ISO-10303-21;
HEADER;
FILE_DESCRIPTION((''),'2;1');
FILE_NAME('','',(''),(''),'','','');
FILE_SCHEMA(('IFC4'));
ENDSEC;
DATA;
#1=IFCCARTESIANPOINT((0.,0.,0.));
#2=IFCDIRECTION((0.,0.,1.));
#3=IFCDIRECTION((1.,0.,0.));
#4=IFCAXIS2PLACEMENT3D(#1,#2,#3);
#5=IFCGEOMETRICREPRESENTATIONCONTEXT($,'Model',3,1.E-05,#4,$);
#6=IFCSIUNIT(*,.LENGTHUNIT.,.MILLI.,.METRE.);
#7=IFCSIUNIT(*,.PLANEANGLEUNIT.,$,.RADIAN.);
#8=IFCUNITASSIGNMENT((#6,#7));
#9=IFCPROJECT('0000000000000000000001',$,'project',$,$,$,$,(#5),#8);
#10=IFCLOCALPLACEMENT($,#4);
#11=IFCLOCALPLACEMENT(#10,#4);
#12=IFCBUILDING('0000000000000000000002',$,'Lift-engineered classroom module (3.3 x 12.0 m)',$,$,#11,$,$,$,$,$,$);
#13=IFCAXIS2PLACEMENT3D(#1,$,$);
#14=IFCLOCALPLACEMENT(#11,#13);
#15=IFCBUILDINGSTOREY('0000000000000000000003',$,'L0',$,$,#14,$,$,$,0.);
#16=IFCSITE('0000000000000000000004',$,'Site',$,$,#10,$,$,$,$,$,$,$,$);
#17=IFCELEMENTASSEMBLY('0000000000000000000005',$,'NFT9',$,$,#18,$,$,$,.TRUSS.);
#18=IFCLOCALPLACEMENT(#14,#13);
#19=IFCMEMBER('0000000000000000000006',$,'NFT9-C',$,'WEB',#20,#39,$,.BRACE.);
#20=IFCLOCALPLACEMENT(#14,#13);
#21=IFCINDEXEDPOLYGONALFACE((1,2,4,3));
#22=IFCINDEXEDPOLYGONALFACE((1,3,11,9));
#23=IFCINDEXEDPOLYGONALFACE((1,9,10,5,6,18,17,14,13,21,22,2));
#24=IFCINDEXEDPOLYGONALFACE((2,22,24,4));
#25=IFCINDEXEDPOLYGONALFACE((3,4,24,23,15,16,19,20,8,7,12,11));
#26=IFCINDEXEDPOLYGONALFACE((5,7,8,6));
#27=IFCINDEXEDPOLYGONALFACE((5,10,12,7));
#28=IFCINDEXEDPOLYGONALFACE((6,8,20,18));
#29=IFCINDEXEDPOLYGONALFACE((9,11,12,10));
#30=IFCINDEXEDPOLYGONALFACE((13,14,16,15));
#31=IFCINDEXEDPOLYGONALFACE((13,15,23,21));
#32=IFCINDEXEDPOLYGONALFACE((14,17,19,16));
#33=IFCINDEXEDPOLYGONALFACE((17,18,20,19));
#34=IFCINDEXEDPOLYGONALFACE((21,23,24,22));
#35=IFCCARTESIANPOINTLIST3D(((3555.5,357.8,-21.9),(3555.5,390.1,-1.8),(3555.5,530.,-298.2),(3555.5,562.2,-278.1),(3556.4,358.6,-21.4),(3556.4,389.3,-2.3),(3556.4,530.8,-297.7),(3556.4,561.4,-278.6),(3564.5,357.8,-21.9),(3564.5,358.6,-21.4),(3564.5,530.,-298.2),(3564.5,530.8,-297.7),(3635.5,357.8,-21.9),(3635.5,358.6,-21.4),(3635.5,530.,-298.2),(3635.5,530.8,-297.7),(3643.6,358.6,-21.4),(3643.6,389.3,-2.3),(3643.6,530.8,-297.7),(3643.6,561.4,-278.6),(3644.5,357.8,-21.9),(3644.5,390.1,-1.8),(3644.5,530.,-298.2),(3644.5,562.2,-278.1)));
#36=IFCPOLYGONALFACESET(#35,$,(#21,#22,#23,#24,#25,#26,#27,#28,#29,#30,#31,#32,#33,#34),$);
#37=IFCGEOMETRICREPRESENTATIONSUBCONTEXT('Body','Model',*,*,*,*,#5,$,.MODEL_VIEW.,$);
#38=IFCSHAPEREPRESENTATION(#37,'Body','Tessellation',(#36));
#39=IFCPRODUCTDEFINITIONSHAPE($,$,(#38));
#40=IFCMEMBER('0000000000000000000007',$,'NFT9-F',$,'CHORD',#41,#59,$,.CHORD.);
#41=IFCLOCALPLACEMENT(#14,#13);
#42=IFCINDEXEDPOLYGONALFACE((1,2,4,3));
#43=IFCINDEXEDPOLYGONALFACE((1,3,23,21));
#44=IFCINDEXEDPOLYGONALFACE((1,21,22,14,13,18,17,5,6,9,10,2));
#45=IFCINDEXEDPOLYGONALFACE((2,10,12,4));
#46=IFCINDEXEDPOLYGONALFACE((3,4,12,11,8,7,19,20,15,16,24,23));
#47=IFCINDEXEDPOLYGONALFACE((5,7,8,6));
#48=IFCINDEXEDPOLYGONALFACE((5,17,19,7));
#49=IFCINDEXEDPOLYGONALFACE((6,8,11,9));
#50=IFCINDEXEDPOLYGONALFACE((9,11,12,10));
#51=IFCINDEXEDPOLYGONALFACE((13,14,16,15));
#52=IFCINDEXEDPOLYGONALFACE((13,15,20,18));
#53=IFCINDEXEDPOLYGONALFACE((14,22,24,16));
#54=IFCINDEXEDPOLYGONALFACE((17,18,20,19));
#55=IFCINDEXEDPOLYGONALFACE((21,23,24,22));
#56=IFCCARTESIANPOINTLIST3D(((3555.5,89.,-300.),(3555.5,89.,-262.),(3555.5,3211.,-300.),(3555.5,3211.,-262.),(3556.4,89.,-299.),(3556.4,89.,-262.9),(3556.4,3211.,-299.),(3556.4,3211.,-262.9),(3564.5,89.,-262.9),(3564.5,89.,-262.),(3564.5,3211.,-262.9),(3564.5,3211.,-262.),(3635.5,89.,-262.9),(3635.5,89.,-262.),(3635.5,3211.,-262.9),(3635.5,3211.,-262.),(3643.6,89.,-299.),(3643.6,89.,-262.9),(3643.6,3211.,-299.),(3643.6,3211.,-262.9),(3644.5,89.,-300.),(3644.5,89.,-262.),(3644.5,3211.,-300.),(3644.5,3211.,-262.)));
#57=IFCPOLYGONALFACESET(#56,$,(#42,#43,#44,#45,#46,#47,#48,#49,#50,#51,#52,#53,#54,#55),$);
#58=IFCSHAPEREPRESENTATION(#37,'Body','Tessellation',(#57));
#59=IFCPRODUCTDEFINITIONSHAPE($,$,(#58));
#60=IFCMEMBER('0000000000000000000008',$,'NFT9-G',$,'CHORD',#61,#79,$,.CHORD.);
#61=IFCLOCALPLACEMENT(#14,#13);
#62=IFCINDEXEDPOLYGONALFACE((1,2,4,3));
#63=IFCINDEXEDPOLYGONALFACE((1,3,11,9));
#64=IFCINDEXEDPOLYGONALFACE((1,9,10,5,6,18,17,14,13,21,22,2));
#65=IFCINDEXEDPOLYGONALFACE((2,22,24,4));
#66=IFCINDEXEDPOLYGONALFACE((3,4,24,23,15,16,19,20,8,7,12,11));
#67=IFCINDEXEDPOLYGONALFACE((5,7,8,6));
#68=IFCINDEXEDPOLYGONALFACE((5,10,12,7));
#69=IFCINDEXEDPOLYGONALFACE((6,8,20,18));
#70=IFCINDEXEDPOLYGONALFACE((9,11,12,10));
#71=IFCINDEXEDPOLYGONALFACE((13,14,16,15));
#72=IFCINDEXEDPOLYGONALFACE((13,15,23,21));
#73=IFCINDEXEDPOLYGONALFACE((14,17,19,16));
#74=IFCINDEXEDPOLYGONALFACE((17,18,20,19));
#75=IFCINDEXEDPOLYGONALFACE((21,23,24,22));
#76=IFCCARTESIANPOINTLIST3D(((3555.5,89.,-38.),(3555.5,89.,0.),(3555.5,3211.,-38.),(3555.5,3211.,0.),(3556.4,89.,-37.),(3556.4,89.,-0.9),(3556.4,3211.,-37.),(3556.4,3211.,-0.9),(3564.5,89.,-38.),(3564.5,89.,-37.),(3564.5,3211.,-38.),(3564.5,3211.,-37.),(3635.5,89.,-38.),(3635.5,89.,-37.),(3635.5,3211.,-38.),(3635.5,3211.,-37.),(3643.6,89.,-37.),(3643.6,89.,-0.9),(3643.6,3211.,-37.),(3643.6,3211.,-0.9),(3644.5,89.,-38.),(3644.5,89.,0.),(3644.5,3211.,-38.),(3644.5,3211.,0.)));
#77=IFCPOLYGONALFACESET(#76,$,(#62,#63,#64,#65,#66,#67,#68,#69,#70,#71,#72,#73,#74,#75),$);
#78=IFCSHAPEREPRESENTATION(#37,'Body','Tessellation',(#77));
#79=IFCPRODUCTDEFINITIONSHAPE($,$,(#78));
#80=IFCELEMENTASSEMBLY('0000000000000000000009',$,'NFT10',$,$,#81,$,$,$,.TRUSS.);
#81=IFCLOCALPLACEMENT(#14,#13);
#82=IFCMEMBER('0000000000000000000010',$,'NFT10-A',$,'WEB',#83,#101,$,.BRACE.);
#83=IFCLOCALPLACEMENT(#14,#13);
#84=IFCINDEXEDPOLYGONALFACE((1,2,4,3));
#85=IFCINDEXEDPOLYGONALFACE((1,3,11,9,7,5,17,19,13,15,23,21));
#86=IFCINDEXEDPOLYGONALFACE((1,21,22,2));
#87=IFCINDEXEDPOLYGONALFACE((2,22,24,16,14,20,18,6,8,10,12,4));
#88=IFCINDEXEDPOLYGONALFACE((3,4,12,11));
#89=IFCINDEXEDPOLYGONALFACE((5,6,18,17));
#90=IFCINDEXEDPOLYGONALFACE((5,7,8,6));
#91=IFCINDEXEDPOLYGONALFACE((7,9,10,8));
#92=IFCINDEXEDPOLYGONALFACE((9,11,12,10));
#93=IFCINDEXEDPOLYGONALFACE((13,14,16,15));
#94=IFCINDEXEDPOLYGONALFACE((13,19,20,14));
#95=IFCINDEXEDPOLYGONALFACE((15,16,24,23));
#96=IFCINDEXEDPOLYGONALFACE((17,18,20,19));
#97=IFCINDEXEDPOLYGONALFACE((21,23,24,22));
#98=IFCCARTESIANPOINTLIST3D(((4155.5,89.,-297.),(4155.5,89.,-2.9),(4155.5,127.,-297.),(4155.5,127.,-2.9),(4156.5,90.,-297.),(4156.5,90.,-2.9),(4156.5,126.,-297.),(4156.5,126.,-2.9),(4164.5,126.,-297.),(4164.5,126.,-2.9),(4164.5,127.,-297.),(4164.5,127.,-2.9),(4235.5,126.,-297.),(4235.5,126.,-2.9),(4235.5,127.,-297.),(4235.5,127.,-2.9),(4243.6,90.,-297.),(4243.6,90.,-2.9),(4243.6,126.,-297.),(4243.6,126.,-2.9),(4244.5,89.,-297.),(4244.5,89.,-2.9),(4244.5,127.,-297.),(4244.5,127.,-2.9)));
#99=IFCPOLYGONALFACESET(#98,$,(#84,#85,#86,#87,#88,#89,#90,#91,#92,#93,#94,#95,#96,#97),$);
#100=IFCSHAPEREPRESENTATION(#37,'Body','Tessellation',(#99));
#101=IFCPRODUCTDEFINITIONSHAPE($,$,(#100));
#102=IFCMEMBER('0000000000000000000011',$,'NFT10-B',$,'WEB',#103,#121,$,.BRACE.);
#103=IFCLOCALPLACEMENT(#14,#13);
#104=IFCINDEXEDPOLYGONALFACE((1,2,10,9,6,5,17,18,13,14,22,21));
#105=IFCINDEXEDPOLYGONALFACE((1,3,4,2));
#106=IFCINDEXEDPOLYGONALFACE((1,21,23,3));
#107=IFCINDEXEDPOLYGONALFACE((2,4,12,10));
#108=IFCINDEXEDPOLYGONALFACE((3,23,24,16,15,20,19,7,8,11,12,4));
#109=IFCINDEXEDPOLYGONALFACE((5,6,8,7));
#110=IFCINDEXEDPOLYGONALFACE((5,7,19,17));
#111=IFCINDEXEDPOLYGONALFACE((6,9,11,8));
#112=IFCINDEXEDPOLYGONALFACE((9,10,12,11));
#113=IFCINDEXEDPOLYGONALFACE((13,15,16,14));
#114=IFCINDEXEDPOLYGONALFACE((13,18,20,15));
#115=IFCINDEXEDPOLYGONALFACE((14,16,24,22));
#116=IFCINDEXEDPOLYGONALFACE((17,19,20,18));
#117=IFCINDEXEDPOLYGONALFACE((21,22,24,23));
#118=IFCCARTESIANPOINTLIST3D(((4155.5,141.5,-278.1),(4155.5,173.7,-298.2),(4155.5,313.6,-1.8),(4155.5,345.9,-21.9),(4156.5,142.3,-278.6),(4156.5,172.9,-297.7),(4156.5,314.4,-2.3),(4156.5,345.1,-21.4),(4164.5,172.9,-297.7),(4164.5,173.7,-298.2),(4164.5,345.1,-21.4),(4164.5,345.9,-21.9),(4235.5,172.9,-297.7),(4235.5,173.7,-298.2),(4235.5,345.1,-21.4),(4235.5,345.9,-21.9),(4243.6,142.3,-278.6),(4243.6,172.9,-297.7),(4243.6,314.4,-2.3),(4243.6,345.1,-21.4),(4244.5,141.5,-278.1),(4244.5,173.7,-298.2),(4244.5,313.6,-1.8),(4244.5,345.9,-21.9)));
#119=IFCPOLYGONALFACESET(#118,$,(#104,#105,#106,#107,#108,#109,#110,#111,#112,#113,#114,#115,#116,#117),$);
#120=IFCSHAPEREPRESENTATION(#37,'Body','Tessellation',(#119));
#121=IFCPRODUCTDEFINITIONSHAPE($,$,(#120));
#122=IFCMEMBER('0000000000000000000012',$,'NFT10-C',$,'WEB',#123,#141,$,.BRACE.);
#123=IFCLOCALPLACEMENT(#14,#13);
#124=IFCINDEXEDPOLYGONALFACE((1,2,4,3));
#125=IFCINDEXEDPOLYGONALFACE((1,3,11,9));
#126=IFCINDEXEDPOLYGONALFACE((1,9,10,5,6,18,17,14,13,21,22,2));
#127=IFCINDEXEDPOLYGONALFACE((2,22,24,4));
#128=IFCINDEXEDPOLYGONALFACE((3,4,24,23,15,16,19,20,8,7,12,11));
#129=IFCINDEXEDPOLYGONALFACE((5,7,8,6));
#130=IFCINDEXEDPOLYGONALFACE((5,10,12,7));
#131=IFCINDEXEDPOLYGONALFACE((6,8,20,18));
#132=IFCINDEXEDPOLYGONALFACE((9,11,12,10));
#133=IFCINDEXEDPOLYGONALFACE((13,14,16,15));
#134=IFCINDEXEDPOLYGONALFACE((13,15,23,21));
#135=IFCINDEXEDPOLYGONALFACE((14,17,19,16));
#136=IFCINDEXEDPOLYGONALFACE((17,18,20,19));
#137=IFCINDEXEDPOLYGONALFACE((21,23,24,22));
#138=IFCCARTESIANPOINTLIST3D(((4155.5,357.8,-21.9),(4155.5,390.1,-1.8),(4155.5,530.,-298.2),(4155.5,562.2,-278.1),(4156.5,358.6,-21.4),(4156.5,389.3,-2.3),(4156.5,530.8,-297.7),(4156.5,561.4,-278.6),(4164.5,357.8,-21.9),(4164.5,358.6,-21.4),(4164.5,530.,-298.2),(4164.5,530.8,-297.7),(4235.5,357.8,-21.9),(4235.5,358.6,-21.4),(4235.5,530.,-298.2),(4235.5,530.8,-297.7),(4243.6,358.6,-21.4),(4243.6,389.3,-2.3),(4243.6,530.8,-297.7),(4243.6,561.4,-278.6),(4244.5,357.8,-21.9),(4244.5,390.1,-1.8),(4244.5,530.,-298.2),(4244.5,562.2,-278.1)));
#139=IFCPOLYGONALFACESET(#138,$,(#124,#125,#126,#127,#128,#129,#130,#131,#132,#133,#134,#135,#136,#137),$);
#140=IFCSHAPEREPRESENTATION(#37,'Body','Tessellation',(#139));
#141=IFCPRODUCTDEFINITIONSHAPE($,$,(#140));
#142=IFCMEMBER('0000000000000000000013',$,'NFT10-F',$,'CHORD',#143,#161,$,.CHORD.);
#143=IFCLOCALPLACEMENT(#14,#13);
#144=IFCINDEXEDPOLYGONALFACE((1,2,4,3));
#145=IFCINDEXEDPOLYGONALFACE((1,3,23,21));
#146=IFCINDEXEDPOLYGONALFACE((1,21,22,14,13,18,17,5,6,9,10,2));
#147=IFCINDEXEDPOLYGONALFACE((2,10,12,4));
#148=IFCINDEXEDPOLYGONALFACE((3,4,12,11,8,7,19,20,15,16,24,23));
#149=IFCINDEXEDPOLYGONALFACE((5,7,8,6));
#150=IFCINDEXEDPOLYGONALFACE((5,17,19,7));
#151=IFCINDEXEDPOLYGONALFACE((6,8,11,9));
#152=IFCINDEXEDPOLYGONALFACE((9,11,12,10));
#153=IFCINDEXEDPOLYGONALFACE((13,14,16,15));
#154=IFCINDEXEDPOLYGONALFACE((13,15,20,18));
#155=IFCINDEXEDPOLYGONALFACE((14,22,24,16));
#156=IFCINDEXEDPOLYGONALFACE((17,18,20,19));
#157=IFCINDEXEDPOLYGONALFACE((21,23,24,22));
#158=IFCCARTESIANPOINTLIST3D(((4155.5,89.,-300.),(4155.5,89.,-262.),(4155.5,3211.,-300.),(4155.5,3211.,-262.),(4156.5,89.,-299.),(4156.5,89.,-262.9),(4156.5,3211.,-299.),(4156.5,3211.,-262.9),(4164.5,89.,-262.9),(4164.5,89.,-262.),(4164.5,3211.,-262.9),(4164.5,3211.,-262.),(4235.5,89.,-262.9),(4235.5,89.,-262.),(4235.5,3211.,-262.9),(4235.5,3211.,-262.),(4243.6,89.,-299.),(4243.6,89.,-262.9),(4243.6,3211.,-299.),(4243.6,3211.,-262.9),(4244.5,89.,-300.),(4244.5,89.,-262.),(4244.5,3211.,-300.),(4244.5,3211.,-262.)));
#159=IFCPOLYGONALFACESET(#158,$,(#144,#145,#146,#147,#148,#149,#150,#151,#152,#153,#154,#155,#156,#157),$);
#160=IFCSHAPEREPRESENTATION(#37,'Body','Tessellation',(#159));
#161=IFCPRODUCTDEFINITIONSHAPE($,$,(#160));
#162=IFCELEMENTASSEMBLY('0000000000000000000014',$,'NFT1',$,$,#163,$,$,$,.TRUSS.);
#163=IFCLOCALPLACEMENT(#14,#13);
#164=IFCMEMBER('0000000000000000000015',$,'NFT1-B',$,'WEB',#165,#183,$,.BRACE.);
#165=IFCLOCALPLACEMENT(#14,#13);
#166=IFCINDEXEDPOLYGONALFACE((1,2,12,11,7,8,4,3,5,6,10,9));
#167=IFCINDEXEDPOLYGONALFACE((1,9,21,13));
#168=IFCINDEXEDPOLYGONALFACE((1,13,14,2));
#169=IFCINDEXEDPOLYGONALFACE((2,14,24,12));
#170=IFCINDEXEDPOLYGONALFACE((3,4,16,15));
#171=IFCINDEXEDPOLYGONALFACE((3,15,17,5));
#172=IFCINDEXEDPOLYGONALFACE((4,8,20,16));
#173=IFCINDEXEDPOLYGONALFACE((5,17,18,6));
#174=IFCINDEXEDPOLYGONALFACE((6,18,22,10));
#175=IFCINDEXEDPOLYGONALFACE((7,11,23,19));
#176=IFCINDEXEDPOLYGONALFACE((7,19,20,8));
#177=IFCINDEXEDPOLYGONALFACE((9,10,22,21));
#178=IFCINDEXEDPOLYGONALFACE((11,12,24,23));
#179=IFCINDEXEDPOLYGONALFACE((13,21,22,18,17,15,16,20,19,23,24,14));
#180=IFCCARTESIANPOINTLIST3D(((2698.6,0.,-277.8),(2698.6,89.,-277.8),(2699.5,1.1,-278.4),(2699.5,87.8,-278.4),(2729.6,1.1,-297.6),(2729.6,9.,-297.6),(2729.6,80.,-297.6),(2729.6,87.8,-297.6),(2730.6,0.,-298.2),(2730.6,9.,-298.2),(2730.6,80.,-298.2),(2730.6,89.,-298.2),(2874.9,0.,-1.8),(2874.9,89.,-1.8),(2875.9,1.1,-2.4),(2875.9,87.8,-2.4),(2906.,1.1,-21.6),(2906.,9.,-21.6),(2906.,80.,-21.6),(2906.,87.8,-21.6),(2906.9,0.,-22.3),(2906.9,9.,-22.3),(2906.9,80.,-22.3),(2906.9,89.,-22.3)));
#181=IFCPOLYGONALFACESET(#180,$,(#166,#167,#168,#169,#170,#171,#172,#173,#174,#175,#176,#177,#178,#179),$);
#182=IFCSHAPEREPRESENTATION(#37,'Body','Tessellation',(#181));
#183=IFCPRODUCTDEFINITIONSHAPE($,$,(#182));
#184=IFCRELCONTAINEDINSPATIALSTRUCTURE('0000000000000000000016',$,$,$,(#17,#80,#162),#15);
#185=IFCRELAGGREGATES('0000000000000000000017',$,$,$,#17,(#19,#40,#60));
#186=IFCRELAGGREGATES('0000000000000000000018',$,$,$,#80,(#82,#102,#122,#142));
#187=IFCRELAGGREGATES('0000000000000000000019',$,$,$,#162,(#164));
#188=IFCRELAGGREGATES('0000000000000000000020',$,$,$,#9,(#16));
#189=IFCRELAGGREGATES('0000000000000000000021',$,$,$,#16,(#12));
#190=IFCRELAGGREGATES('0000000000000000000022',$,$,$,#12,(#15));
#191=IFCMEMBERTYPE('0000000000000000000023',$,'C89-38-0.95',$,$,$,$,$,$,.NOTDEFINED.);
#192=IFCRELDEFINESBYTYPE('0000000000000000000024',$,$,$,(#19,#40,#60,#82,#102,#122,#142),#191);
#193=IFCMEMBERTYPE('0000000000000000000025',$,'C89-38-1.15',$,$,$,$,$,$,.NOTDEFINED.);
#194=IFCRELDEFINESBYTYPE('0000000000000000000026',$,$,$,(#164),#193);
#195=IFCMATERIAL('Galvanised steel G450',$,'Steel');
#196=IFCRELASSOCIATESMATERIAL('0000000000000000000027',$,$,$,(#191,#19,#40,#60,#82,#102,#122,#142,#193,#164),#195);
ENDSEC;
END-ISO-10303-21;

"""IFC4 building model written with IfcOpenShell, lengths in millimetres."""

from ifc_helpers import new_model, si_unit, frame, origin, origin_with_axes, origin_2d, place, context, subcontext, project, spatial, c_section, extrude, material, material_profile, profile_set, profile_usage, type_object, element, aggregate, save


model = new_model("IFC4")

# Units and contexts
model_context = context("Model", 3, precision=1e-05, world=origin_with_axes())
body_context = subcontext(model_context, "Body", "Model", "MODEL_VIEW")
ifc_project = project(units=[si_unit("LENGTHUNIT", "METRE", prefix="MILLI"), si_unit("PLANEANGLEUNIT", "RADIAN")], contexts=[model_context])

# Site, building, storey
site_placement = place(None, origin_with_axes())
site = spatial("IfcSite", under=ifc_project, at=site_placement, Name="Site")
building_placement = place(site_placement, origin_with_axes())
building = spatial("IfcBuilding", under=site, at=building_placement, Name="Lift-engineered classroom module (3.3 x 12.0 m)")
storey_placement = place(building_placement, origin())
storey = spatial("IfcBuildingStorey", under=building, at=storey_placement, Name="L0", Elevation=0.0)

# Element assemblies, members
ifc_material = material(Name="Galvanised steel G450", Category="Steel")
ifc_material_profile_1 = material_profile(ifc_material, c_section(Depth=89.0, Width=38.0, WallThickness=0.9, Girth=9.0, at=origin_2d()), Name="C89-38-0.95")
ifc_profile_set_1 = profile_set([ifc_material_profile_1], Name="C89-38-0.95")
ifc_profile_usage_1 = profile_usage(ifc_profile_set_1)
member_type_1 = type_object("IfcMemberType", Name="C89-38-0.95", PredefinedType="NOTDEFINED", material=ifc_profile_set_1)
assembly_1_placement = place(storey_placement, frame((3600.0, 89.0, -300.0)))
assembly_1 = element("IfcElementAssembly", 1, at=assembly_1_placement, inside=storey, Name="NFT9", PredefinedType="TRUSS")
member_1_placement = place(assembly_1_placement, frame((0.0, 457.1, 11.8), z_axis=(0.0, -0.528797, 0.848748), x_axis=(0.0, -0.848748, -0.528797)))
member_1 = element("IfcMember", 2, at=member_1_placement, type_object=member_type_1, material=ifc_profile_usage_1, Name="NFT9-C", ObjectType="WEB", PredefinedType="BRACE", context=body_context, shape_type="SweptSolid", body=[
    extrude(c_section(Depth=89.0, Width=38.0, WallThickness=0.9, Girth=9.0, at=origin_2d()), origin(), (0.0, 0.0, 1.0), 325.6),
])
member_2_placement = place(assembly_1_placement, frame((0.0, 0.0, 19.0), z_axis=(0.0, 1.0, 0.0), x_axis=(0.0, 0.0, 1.0)))
member_2 = element("IfcMember", 3, at=member_2_placement, type_object=member_type_1, material=ifc_profile_usage_1, Name="NFT9-F", ObjectType="CHORD", PredefinedType="CHORD", context=body_context, shape_type="SweptSolid", body=[
    extrude(c_section(Depth=89.0, Width=38.0, WallThickness=0.9, Girth=9.0, at=origin_2d()), origin(), (0.0, 0.0, 1.0), 3122.0),
])
member_3_placement = place(assembly_1_placement, frame((0.0, 0.0, 281.0), z_axis=(0.0, 1.0, 0.0), x_axis=(0.0, 0.0, -1.0)))
member_3 = element("IfcMember", 4, at=member_3_placement, type_object=member_type_1, material=ifc_profile_usage_1, Name="NFT9-G", ObjectType="CHORD", PredefinedType="CHORD", context=body_context, shape_type="SweptSolid", body=[
    extrude(c_section(Depth=89.0, Width=38.0, WallThickness=0.9, Girth=9.0, at=origin_2d()), origin(), (0.0, 0.0, 1.0), 3122.0),
])
aggregate(assembly_1, [member_1, member_2, member_3])
assembly_2_placement = place(storey_placement, frame((4200.0, 89.0, -300.0)))
assembly_2 = element("IfcElementAssembly", 5, at=assembly_2_placement, inside=storey, Name="NFT10", PredefinedType="TRUSS")
member_4_placement = place(assembly_2_placement, frame((0.0, 19.0, 2.9), z_axis=(0.0, 0.0, 1.0), x_axis=(0.0, 1.0, 0.0)))
member_4 = element("IfcMember", 6, at=member_4_placement, type_object=member_type_1, material=ifc_profile_usage_1, Name="NFT10-A", ObjectType="WEB", PredefinedType="BRACE", context=body_context, shape_type="SweptSolid", body=[
    extrude(c_section(Depth=89.0, Width=38.0, WallThickness=0.9, Girth=9.0, at=origin_2d()), origin(), (0.0, 0.0, 1.0), 294.1),
])
member_5_placement = place(assembly_2_placement, frame((0.0, 68.6, 11.8), z_axis=(0.0, 0.528797, 0.848748), x_axis=(0.0, 0.848748, -0.528797)))
member_5 = element("IfcMember", 7, at=member_5_placement, type_object=member_type_1, material=ifc_profile_usage_1, Name="NFT10-B", ObjectType="WEB", PredefinedType="BRACE", context=body_context, shape_type="SweptSolid", body=[
    extrude(c_section(Depth=89.0, Width=38.0, WallThickness=0.9, Girth=9.0, at=origin_2d()), origin(), (0.0, 0.0, 1.0), 325.6),
])
member_6_placement = place(assembly_2_placement, frame((0.0, 457.1, 11.8), z_axis=(0.0, -0.528797, 0.848748), x_axis=(0.0, -0.848748, -0.528797)))
member_6 = element("IfcMember", 8, at=member_6_placement, type_object=member_type_1, material=ifc_profile_usage_1, Name="NFT10-C", ObjectType="WEB", PredefinedType="BRACE", context=body_context, shape_type="SweptSolid", body=[
    extrude(c_section(Depth=89.0, Width=38.0, WallThickness=0.9, Girth=9.0, at=origin_2d()), origin(), (0.0, 0.0, 1.0), 325.6),
])
member_7_placement = place(assembly_2_placement, frame((0.0, 0.0, 19.0), z_axis=(0.0, 1.0, 0.0), x_axis=(0.0, 0.0, 1.0)))
member_7 = element("IfcMember", 9, at=member_7_placement, type_object=member_type_1, material=ifc_profile_usage_1, Name="NFT10-F", ObjectType="CHORD", PredefinedType="CHORD", context=body_context, shape_type="SweptSolid", body=[
    extrude(c_section(Depth=89.0, Width=38.0, WallThickness=0.9, Girth=9.0, at=origin_2d()), origin(), (0.0, 0.0, 1.0), 3122.0),
])
aggregate(assembly_2, [member_4, member_5, member_6, member_7])
assembly_3_placement = place(storey_placement, frame((0.0, 44.5, -300.0)))
assembly_3 = element("IfcElementAssembly", 10, at=assembly_3_placement, inside=storey, Name="NFT1", PredefinedType="TRUSS")
ifc_material_profile_2 = material_profile(ifc_material, c_section(Depth=89.0, Width=38.0, WallThickness=1.1, Girth=9.0, at=origin_2d()), Name="C89-38-1.15")
ifc_profile_set_2 = profile_set([ifc_material_profile_2], Name="C89-38-1.15")
ifc_profile_usage_2 = profile_usage(ifc_profile_set_2)
member_type_2 = type_object("IfcMemberType", Name="C89-38-1.15", PredefinedType="NOTDEFINED", material=ifc_profile_set_2)
member_8_placement = place(assembly_3_placement, frame((2714.6, 0.0, 12.0), z_axis=(0.538459, 0.0, 0.842652), x_axis=(0.842652, 0.0, -0.538459)))
member_8 = element("IfcMember", 11, at=member_8_placement, type_object=member_type_2, material=ifc_profile_usage_2, Name="NFT1-B", ObjectType="WEB", PredefinedType="BRACE", context=body_context, shape_type="SweptSolid", body=[
    extrude(c_section(Depth=89.0, Width=38.0, WallThickness=1.1, Girth=9.0, at=origin_2d()), origin(), (0.0, 0.0, 1.0), 327.5),
])
aggregate(assembly_3, [member_8])

save(model, "model.ifc")
